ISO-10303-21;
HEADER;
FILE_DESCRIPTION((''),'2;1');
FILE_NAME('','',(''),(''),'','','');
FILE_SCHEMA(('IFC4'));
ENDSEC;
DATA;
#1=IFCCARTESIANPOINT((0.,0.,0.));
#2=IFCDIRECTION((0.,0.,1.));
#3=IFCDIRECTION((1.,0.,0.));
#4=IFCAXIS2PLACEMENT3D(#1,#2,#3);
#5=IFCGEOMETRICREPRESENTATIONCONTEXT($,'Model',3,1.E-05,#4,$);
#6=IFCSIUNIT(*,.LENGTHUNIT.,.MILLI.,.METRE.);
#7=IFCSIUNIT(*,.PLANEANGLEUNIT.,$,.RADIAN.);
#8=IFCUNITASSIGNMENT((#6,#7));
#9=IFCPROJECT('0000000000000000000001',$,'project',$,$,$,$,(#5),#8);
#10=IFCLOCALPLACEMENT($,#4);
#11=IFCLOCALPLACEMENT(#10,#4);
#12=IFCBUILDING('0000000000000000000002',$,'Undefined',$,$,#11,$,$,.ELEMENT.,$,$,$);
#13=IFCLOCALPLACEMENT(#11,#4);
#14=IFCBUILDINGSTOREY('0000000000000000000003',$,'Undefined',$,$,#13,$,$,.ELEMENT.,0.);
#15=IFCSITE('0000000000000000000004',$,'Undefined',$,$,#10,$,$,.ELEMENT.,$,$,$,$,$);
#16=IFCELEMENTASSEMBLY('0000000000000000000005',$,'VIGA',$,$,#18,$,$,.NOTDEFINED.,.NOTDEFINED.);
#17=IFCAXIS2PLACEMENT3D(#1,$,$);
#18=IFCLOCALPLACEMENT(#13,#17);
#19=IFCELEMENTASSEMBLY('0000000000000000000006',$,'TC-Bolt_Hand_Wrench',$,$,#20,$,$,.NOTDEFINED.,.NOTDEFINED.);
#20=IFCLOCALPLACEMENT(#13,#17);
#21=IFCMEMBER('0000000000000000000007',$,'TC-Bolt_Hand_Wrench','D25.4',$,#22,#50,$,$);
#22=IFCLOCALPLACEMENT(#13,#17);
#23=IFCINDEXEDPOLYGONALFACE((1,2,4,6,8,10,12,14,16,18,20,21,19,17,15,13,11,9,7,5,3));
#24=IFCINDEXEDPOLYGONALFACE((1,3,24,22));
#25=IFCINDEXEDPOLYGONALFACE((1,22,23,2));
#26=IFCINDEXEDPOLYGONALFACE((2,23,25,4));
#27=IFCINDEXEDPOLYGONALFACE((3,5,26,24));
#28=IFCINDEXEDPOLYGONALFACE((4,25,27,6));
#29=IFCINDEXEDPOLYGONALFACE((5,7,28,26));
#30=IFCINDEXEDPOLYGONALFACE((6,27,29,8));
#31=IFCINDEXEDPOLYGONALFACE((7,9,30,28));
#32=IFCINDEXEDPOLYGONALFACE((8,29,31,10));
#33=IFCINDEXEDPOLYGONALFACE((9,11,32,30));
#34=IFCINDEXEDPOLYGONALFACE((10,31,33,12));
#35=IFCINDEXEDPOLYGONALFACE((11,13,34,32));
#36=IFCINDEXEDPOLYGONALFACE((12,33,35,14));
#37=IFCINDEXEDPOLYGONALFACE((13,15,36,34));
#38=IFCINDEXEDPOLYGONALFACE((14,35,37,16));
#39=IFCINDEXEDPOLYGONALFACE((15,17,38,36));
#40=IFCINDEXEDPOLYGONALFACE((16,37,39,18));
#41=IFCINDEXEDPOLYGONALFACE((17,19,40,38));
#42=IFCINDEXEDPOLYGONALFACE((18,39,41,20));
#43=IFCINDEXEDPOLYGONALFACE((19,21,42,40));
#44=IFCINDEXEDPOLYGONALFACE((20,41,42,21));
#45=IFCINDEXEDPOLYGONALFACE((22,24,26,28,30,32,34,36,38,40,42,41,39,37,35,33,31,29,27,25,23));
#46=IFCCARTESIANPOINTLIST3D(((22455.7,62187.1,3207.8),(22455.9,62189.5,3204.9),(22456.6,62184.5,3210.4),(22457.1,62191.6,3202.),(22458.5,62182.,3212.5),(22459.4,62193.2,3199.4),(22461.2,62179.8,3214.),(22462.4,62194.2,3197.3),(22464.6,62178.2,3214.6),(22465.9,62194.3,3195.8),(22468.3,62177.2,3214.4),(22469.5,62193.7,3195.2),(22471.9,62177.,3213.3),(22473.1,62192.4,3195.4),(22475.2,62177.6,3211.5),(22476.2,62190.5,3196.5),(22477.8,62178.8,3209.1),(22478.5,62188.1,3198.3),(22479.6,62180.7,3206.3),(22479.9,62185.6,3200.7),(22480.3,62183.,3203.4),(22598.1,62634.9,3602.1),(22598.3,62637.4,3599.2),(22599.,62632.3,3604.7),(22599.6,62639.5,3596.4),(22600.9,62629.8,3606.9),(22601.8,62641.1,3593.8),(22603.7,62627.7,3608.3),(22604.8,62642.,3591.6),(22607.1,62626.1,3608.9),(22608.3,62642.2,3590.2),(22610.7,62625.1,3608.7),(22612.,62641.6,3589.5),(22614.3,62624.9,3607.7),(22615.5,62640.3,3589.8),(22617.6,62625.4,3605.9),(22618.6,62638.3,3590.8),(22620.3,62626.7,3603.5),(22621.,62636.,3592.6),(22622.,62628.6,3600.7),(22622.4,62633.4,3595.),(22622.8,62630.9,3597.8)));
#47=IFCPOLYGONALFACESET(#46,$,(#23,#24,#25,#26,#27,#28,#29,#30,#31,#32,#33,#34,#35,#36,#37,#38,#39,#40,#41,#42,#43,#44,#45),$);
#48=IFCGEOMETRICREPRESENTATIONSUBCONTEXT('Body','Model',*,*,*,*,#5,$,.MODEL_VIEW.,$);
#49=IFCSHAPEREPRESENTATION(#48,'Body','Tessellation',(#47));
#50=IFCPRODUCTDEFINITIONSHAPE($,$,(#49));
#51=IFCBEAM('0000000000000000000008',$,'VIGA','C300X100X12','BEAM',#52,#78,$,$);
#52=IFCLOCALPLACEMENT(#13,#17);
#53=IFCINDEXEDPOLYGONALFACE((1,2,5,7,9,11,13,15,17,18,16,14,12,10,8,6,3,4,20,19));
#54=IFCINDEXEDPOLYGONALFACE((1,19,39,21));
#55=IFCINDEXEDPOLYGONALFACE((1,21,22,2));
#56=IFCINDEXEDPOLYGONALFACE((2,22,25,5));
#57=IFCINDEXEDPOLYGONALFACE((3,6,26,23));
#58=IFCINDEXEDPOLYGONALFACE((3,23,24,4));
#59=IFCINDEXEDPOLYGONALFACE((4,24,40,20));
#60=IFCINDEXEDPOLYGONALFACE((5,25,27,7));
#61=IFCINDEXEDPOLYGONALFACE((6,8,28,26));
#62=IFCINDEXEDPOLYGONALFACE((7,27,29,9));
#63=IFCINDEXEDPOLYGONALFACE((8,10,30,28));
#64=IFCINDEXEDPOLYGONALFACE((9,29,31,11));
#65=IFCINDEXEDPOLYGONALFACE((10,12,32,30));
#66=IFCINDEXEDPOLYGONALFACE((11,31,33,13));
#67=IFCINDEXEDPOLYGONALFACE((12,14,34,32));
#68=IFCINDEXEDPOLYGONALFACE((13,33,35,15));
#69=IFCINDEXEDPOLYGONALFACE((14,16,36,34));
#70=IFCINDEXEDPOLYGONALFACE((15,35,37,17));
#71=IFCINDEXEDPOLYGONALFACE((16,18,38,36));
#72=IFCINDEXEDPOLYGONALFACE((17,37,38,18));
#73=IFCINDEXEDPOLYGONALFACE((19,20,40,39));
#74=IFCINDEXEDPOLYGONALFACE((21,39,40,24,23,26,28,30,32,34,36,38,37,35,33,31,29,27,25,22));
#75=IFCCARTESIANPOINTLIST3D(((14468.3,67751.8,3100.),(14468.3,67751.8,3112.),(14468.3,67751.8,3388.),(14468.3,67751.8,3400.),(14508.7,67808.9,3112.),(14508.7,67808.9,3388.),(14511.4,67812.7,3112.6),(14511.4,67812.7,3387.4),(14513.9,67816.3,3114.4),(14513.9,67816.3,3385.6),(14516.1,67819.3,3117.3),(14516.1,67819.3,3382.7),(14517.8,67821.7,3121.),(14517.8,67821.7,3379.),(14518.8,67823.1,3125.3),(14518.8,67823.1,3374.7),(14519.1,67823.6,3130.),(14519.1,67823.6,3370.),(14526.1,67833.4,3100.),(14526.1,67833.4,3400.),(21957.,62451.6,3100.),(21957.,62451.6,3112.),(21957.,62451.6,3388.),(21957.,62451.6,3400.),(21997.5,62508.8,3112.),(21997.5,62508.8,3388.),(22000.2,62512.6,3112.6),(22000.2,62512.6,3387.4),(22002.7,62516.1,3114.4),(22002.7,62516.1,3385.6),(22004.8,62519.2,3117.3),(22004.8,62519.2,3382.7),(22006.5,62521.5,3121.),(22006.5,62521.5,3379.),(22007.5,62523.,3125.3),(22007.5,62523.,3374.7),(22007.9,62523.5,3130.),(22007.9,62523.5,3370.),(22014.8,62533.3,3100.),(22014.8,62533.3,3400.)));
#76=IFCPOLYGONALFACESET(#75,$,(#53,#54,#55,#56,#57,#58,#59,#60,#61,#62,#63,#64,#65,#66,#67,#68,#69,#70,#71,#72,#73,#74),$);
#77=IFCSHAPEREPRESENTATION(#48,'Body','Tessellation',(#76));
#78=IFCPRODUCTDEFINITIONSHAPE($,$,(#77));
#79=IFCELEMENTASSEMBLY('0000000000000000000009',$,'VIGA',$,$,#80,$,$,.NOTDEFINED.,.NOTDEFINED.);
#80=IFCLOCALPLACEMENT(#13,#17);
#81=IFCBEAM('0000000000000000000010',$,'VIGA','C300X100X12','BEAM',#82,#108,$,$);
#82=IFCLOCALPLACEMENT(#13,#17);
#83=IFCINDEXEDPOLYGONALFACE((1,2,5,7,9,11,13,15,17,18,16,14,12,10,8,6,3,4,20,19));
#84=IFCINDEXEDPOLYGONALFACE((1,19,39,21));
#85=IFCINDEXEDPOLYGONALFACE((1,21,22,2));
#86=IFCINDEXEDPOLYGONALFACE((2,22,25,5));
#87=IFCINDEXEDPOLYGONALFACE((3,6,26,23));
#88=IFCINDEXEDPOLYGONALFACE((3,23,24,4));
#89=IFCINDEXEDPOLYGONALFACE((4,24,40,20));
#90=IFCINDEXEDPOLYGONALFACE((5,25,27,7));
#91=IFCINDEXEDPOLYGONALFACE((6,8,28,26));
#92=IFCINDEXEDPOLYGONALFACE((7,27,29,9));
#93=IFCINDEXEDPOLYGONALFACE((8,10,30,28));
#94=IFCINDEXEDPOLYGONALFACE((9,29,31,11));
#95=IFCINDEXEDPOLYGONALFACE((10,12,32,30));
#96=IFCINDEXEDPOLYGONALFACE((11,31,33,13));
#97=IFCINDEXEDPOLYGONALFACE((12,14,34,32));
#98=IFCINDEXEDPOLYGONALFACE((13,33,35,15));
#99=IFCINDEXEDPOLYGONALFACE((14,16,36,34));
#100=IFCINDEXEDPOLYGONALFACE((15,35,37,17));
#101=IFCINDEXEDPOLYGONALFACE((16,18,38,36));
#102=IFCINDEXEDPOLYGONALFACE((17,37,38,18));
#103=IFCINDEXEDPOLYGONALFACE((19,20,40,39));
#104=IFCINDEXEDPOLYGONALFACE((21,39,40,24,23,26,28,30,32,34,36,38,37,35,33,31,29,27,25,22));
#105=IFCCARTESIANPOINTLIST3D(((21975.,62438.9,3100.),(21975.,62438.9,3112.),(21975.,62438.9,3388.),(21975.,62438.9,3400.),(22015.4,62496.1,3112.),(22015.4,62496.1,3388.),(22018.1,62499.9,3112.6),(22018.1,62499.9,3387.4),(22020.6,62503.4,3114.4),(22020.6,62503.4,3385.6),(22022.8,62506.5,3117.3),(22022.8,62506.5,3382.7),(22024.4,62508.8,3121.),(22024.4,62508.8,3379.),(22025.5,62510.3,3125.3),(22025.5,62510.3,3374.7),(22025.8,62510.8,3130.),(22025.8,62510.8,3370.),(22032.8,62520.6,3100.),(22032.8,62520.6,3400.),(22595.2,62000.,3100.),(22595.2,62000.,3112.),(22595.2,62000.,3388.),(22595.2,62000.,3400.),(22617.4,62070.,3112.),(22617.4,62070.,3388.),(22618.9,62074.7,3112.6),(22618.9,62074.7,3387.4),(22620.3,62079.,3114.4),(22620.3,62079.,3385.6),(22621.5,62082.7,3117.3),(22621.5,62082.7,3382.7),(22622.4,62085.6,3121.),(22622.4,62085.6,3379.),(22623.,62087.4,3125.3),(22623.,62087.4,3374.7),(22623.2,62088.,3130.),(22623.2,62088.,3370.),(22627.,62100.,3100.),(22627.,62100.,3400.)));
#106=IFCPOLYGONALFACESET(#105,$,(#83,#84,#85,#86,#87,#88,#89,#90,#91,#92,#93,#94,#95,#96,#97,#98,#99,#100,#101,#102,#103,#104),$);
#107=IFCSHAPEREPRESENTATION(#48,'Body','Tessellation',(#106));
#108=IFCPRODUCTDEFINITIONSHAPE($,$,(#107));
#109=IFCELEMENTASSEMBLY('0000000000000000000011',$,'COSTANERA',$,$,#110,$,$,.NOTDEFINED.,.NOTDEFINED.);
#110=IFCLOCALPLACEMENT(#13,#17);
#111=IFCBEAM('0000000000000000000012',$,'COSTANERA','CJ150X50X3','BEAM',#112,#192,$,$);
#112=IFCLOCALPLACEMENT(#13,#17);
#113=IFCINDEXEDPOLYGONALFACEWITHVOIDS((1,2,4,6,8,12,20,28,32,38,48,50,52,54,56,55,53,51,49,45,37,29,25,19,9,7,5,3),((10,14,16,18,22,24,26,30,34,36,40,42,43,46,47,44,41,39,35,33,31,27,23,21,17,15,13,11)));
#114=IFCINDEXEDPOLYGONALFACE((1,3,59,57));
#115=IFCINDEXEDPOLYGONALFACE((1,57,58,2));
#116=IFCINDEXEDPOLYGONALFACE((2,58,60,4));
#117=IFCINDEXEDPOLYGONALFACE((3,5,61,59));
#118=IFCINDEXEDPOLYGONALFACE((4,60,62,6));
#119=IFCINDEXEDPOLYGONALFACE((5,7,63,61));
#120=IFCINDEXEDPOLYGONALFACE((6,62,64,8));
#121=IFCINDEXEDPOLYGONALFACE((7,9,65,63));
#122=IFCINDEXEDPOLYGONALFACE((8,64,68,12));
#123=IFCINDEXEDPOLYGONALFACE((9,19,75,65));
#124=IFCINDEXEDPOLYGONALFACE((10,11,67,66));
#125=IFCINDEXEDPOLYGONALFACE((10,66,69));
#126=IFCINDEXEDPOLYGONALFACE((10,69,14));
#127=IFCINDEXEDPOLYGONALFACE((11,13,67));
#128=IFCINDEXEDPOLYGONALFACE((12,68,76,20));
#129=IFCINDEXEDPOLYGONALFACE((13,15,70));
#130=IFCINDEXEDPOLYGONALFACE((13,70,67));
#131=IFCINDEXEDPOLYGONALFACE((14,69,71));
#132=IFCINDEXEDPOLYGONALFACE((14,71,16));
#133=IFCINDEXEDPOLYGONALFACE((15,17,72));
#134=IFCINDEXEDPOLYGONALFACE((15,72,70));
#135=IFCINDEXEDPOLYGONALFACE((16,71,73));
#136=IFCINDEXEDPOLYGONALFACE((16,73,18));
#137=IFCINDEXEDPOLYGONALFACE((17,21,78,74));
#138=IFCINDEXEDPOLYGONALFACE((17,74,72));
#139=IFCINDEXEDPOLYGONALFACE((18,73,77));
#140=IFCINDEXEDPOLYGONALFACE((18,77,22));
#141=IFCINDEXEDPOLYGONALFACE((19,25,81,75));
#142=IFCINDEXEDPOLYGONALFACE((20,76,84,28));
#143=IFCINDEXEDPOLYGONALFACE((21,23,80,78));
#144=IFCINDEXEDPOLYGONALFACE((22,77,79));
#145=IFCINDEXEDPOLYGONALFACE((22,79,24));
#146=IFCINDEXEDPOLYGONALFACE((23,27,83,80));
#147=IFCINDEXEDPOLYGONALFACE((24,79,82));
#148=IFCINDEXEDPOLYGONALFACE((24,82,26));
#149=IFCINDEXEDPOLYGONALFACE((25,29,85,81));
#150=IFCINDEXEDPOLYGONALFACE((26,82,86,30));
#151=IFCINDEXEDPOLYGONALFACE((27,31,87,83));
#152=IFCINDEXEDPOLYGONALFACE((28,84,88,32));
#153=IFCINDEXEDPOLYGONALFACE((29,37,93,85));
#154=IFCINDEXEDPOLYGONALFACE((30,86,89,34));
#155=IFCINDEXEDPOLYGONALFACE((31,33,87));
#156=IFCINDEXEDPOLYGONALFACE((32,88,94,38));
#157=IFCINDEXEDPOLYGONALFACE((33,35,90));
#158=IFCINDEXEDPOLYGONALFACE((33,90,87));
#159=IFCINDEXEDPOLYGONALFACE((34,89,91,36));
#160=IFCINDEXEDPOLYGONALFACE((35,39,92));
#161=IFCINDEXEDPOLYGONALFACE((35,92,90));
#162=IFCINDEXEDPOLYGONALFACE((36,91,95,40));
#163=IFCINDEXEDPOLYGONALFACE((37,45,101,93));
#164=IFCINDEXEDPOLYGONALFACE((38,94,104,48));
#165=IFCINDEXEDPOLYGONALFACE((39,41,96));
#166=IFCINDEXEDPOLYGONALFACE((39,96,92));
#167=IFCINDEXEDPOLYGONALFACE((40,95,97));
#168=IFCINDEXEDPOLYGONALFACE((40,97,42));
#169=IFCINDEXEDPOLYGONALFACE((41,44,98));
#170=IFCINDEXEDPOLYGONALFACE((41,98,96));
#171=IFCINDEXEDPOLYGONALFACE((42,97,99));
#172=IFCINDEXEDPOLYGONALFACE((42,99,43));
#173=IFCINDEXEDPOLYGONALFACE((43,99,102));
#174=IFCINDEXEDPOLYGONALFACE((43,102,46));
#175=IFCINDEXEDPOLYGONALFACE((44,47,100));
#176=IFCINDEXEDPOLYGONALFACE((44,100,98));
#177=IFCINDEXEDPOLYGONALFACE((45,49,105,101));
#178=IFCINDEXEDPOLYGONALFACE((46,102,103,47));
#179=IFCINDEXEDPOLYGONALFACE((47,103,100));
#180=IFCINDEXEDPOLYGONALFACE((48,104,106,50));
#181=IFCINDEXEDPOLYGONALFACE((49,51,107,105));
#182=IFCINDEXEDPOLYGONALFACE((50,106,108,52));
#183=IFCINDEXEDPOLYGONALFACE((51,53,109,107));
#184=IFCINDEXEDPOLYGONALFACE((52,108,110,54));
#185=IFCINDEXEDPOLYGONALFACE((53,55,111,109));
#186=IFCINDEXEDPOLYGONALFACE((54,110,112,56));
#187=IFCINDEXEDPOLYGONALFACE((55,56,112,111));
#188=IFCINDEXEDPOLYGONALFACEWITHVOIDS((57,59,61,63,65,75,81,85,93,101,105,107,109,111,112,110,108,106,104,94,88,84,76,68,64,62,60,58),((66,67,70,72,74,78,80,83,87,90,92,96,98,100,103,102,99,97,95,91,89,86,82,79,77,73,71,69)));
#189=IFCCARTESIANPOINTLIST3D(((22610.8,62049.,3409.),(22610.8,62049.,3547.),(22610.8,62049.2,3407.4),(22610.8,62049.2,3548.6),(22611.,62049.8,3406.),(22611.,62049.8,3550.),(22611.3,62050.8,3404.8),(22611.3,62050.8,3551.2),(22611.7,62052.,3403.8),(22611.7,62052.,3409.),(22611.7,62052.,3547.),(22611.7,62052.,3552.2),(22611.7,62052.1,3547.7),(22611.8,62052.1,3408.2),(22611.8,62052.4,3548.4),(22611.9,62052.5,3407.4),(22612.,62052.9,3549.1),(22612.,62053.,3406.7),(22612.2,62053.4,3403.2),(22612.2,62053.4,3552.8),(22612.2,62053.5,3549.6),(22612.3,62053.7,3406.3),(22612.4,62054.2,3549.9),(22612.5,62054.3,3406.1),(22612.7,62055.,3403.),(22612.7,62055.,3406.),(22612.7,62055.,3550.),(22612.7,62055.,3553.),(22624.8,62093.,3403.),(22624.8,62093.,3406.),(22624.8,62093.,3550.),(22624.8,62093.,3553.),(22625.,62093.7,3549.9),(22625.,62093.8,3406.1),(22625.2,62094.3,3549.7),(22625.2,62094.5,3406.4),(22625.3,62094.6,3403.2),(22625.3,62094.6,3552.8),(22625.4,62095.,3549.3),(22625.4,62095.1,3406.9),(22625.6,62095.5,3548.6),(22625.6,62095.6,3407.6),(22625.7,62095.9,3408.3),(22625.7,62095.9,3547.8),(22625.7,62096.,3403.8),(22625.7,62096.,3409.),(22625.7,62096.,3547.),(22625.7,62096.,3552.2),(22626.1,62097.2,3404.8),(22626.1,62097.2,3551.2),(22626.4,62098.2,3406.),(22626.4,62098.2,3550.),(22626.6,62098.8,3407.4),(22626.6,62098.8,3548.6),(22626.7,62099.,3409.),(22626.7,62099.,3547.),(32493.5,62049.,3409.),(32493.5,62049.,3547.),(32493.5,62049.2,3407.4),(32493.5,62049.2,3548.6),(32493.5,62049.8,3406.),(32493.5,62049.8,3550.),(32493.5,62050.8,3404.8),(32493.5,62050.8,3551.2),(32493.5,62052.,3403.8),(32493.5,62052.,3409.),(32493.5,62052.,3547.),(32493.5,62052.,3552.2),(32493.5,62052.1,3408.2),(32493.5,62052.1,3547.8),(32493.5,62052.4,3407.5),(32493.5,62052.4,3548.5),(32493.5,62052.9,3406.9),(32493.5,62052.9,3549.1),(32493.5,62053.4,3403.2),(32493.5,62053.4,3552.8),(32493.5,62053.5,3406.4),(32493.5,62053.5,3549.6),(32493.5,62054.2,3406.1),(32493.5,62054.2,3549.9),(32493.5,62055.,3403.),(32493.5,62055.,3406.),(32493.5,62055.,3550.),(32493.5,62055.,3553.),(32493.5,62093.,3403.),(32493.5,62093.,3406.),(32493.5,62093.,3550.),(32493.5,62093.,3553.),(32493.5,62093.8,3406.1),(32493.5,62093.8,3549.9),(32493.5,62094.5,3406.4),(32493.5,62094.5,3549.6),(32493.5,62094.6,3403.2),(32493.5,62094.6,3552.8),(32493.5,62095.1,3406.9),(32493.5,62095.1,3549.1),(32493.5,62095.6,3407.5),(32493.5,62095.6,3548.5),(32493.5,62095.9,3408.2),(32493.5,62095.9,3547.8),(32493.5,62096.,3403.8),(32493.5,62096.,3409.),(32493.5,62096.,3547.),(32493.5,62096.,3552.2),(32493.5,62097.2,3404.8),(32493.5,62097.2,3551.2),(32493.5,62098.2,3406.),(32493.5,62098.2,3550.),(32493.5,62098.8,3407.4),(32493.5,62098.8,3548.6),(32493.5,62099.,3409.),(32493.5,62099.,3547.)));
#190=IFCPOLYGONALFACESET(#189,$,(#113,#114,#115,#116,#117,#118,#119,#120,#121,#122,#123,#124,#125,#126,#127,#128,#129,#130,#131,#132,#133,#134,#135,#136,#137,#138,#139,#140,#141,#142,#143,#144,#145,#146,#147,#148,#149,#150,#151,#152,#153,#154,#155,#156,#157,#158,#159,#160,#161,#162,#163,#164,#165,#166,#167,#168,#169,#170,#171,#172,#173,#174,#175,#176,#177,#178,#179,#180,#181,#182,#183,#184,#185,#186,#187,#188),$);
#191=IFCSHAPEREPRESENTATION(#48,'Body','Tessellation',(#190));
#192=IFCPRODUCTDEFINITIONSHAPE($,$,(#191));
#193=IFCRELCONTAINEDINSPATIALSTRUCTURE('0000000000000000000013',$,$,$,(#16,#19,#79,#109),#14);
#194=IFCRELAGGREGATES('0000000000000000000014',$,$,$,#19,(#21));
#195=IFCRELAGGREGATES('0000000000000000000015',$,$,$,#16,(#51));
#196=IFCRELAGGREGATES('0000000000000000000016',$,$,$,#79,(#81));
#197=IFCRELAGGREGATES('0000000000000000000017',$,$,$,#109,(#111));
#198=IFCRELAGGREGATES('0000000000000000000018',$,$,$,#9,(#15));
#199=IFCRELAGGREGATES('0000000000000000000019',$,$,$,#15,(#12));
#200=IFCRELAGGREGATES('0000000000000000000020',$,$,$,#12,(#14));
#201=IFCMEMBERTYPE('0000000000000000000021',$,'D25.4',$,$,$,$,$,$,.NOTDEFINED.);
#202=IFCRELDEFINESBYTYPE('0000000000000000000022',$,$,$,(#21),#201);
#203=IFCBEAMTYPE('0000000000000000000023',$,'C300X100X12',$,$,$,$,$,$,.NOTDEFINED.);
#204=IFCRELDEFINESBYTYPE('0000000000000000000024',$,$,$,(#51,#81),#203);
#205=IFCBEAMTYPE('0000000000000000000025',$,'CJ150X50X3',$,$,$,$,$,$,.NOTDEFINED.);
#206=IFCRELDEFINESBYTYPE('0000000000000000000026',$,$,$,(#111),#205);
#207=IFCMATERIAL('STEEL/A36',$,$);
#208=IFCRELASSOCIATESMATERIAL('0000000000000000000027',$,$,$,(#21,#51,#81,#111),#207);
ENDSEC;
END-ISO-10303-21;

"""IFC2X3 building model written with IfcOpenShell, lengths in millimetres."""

from ifc_helpers import new_model, si_unit, frame, origin_with_axes, origin_2d_with_axis, place, context, subcontext, project, spatial, hollow_rectangle, circle, u_section, extrude, clip, halfspace, material, type_object, element, aggregate, save


model = new_model("IFC2X3")

# Units and contexts
model_context = context("Model", 3, precision=1e-05, world=origin_with_axes())
body_context = subcontext(model_context, "Body", "Model", "MODEL_VIEW")
ifc_project = project(units=[si_unit("LENGTHUNIT", "METRE", prefix="MILLI"), si_unit("PLANEANGLEUNIT", "RADIAN")], contexts=[model_context])

# Site, building, storey
site_placement = place(None, origin_with_axes())
site = spatial("IfcSite", under=ifc_project, at=site_placement, Name="Undefined", CompositionType="ELEMENT")
building_placement = place(site_placement, origin_with_axes())
building = spatial("IfcBuilding", under=site, at=building_placement, Name="Undefined", CompositionType="ELEMENT")
storey_placement = place(building_placement, origin_with_axes())
storey = spatial("IfcBuildingStorey", under=building, at=storey_placement, Name="Undefined", CompositionType="ELEMENT", Elevation=0.0)

# Element assembly
assembly_1_placement = place(storey_placement, origin_with_axes())
assembly_1 = element("IfcElementAssembly", 1, at=assembly_1_placement, inside=storey, Name="VIGA", AssemblyPlace="NOTDEFINED", PredefinedType="NOTDEFINED")
ifc_material_1 = material(Name="STEEL/A36")

# Element assembly, member
assembly_2_placement = place(storey_placement, origin_with_axes())
assembly_2 = element("IfcElementAssembly", 2, at=assembly_2_placement, inside=storey, Name="TC-Bolt_Hand_Wrench", AssemblyPlace="NOTDEFINED", PredefinedType="NOTDEFINED")
member_type = type_object("IfcMemberType", Name="D25.4", PredefinedType="NOTDEFINED")
member_placement = place(assembly_2_placement, frame((22468.0, 62185.7, 3204.9), z_axis=(0.194835, 0.612548, -0.766044), x_axis=(0.232195, 0.730006, 0.642788)))
member = element("IfcMember", 3, at=member_placement, type_object=member_type, material=ifc_material_1, Name="TC-Bolt_Hand_Wrench", Description="D25.4", context=body_context, shape_type="SweptSolid", body=[
    extrude(circle(Radius=12.7, at=origin_2d_with_axis()), frame((613.5, 0.0, 0.0), z_axis=(-1.0, 0.0, 0.0), x_axis=(0.0, -1.0, 0.0)), (0.0, 0.0, 1.0), 613.5),
])
aggregate(assembly_2, [member])

# Beam
beam_type_1 = type_object("IfcBeamType", Name="C300X100X12", PredefinedType="NOTDEFINED")
beam_1_placement = place(assembly_1_placement, frame((21985.9, 62492.5, 3250.0), z_axis=(0.0, 0.0, -1.0), x_axis=(-0.816249, 0.577701, 0.0)))
beam_1 = element("IfcBeam", 4, at=beam_1_placement, type_object=beam_type_1, material=ifc_material_1, Name="VIGA", Description="C300X100X12", ObjectType="BEAM", context=body_context, shape_type="Clipping", body=[
    clip(extrude(u_section(Depth=300.0, FlangeWidth=100.0, WebThickness=12.0, FlangeThickness=12.0, FilletRadius=18.0, at=origin_2d_with_axis()), frame((9269.8, 0.0, 0.0), z_axis=(-1.0, 0.0, 0.0), x_axis=(0.0, -1.0, 0.0)), (0.0, 0.0, 1.0), 9269.8), halfspace(frame((9174.6, 0.0, -250.0), z_axis=(1.0, 0.0, 0.0), x_axis=(0.0, -1.0, 0.0)), False)),
])

# Element assembly, beam
assembly_3_placement = place(storey_placement, origin_with_axes())
assembly_3 = element("IfcElementAssembly", 5, at=assembly_3_placement, inside=storey, Name="VIGA", AssemblyPlace="NOTDEFINED", PredefinedType="NOTDEFINED")
beam_2_placement = place(assembly_3_placement, frame((22598.1, 62059.2, 3250.0), z_axis=(0.0, 0.0, -1.0), x_axis=(-0.816249, 0.577701, 0.0)))
beam_2 = element("IfcBeam", 6, at=beam_2_placement, type_object=beam_type_1, material=ifc_material_1, Name="VIGA", Description="C300X100X12", ObjectType="BEAM", context=body_context, shape_type="Clipping", body=[
    clip(clip(extrude(u_section(Depth=300.0, FlangeWidth=100.0, WebThickness=12.0, FlangeThickness=12.0, FilletRadius=18.0, at=origin_2d_with_axis()), frame((817.9, 0.0, 0.0), z_axis=(-1.0, 0.0, 0.0), x_axis=(0.0, -1.0, 0.0)), (0.0, 0.0, 1.0), 923.7), halfspace(frame((728.0, 0.0, -250.0), z_axis=(1.0, 0.0, 0.0), x_axis=(0.0, -1.0, 0.0)), False)), halfspace(frame((-31.8, -50.0, 0.0), z_axis=(-0.952956, 0.30311, 0.0), x_axis=(0.0, 0.0, -1.0)), False)),
])

# Element assembly, beam
assembly_4_placement = place(storey_placement, origin_with_axes())
assembly_4 = element("IfcElementAssembly", 7, at=assembly_4_placement, inside=storey, Name="COSTANERA", AssemblyPlace="NOTDEFINED", PredefinedType="NOTDEFINED")
beam_type_2 = type_object("IfcBeamType", Name="CJ150X50X3", PredefinedType="NOTDEFINED")
beam_3_placement = place(assembly_4_placement, frame((22618.7, 62074.0, 3478.0), z_axis=(0.0, 0.0, 1.0), x_axis=(1.0, 0.0, 0.0)))
beam_3 = element("IfcBeam", 8, at=beam_3_placement, type_object=beam_type_2, material=ifc_material_1, Name="COSTANERA", Description="CJ150X50X3", ObjectType="BEAM", context=body_context, shape_type="Clipping", body=[
    clip(clip(extrude(hollow_rectangle(XDim=50.0, YDim=150.0, WallThickness=3.0, InnerFilletRadius=3.0, OuterFilletRadius=6.0, at=origin_2d_with_axis()), frame((9882.8, 0.0, 0.0), z_axis=(-1.0, 0.0, 0.0), x_axis=(0.0, -1.0, 0.0)), (0.0, 0.0, 1.0), 9890.9), halfspace(frame((9874.8, 0.0, -1000.0), z_axis=(-1.0, 0.0, 0.0), x_axis=(0.0, 1.0, 0.0)), True)), halfspace(frame((-8.0, -25.0, 0.0), z_axis=(0.952956, -0.30311, 0.0), x_axis=(0.0, 0.0, 1.0)), True)),
])

aggregate(assembly_1, [beam_1])

aggregate(assembly_3, [beam_2])
aggregate(assembly_4, [beam_3])

save(model, "model.ifc")
